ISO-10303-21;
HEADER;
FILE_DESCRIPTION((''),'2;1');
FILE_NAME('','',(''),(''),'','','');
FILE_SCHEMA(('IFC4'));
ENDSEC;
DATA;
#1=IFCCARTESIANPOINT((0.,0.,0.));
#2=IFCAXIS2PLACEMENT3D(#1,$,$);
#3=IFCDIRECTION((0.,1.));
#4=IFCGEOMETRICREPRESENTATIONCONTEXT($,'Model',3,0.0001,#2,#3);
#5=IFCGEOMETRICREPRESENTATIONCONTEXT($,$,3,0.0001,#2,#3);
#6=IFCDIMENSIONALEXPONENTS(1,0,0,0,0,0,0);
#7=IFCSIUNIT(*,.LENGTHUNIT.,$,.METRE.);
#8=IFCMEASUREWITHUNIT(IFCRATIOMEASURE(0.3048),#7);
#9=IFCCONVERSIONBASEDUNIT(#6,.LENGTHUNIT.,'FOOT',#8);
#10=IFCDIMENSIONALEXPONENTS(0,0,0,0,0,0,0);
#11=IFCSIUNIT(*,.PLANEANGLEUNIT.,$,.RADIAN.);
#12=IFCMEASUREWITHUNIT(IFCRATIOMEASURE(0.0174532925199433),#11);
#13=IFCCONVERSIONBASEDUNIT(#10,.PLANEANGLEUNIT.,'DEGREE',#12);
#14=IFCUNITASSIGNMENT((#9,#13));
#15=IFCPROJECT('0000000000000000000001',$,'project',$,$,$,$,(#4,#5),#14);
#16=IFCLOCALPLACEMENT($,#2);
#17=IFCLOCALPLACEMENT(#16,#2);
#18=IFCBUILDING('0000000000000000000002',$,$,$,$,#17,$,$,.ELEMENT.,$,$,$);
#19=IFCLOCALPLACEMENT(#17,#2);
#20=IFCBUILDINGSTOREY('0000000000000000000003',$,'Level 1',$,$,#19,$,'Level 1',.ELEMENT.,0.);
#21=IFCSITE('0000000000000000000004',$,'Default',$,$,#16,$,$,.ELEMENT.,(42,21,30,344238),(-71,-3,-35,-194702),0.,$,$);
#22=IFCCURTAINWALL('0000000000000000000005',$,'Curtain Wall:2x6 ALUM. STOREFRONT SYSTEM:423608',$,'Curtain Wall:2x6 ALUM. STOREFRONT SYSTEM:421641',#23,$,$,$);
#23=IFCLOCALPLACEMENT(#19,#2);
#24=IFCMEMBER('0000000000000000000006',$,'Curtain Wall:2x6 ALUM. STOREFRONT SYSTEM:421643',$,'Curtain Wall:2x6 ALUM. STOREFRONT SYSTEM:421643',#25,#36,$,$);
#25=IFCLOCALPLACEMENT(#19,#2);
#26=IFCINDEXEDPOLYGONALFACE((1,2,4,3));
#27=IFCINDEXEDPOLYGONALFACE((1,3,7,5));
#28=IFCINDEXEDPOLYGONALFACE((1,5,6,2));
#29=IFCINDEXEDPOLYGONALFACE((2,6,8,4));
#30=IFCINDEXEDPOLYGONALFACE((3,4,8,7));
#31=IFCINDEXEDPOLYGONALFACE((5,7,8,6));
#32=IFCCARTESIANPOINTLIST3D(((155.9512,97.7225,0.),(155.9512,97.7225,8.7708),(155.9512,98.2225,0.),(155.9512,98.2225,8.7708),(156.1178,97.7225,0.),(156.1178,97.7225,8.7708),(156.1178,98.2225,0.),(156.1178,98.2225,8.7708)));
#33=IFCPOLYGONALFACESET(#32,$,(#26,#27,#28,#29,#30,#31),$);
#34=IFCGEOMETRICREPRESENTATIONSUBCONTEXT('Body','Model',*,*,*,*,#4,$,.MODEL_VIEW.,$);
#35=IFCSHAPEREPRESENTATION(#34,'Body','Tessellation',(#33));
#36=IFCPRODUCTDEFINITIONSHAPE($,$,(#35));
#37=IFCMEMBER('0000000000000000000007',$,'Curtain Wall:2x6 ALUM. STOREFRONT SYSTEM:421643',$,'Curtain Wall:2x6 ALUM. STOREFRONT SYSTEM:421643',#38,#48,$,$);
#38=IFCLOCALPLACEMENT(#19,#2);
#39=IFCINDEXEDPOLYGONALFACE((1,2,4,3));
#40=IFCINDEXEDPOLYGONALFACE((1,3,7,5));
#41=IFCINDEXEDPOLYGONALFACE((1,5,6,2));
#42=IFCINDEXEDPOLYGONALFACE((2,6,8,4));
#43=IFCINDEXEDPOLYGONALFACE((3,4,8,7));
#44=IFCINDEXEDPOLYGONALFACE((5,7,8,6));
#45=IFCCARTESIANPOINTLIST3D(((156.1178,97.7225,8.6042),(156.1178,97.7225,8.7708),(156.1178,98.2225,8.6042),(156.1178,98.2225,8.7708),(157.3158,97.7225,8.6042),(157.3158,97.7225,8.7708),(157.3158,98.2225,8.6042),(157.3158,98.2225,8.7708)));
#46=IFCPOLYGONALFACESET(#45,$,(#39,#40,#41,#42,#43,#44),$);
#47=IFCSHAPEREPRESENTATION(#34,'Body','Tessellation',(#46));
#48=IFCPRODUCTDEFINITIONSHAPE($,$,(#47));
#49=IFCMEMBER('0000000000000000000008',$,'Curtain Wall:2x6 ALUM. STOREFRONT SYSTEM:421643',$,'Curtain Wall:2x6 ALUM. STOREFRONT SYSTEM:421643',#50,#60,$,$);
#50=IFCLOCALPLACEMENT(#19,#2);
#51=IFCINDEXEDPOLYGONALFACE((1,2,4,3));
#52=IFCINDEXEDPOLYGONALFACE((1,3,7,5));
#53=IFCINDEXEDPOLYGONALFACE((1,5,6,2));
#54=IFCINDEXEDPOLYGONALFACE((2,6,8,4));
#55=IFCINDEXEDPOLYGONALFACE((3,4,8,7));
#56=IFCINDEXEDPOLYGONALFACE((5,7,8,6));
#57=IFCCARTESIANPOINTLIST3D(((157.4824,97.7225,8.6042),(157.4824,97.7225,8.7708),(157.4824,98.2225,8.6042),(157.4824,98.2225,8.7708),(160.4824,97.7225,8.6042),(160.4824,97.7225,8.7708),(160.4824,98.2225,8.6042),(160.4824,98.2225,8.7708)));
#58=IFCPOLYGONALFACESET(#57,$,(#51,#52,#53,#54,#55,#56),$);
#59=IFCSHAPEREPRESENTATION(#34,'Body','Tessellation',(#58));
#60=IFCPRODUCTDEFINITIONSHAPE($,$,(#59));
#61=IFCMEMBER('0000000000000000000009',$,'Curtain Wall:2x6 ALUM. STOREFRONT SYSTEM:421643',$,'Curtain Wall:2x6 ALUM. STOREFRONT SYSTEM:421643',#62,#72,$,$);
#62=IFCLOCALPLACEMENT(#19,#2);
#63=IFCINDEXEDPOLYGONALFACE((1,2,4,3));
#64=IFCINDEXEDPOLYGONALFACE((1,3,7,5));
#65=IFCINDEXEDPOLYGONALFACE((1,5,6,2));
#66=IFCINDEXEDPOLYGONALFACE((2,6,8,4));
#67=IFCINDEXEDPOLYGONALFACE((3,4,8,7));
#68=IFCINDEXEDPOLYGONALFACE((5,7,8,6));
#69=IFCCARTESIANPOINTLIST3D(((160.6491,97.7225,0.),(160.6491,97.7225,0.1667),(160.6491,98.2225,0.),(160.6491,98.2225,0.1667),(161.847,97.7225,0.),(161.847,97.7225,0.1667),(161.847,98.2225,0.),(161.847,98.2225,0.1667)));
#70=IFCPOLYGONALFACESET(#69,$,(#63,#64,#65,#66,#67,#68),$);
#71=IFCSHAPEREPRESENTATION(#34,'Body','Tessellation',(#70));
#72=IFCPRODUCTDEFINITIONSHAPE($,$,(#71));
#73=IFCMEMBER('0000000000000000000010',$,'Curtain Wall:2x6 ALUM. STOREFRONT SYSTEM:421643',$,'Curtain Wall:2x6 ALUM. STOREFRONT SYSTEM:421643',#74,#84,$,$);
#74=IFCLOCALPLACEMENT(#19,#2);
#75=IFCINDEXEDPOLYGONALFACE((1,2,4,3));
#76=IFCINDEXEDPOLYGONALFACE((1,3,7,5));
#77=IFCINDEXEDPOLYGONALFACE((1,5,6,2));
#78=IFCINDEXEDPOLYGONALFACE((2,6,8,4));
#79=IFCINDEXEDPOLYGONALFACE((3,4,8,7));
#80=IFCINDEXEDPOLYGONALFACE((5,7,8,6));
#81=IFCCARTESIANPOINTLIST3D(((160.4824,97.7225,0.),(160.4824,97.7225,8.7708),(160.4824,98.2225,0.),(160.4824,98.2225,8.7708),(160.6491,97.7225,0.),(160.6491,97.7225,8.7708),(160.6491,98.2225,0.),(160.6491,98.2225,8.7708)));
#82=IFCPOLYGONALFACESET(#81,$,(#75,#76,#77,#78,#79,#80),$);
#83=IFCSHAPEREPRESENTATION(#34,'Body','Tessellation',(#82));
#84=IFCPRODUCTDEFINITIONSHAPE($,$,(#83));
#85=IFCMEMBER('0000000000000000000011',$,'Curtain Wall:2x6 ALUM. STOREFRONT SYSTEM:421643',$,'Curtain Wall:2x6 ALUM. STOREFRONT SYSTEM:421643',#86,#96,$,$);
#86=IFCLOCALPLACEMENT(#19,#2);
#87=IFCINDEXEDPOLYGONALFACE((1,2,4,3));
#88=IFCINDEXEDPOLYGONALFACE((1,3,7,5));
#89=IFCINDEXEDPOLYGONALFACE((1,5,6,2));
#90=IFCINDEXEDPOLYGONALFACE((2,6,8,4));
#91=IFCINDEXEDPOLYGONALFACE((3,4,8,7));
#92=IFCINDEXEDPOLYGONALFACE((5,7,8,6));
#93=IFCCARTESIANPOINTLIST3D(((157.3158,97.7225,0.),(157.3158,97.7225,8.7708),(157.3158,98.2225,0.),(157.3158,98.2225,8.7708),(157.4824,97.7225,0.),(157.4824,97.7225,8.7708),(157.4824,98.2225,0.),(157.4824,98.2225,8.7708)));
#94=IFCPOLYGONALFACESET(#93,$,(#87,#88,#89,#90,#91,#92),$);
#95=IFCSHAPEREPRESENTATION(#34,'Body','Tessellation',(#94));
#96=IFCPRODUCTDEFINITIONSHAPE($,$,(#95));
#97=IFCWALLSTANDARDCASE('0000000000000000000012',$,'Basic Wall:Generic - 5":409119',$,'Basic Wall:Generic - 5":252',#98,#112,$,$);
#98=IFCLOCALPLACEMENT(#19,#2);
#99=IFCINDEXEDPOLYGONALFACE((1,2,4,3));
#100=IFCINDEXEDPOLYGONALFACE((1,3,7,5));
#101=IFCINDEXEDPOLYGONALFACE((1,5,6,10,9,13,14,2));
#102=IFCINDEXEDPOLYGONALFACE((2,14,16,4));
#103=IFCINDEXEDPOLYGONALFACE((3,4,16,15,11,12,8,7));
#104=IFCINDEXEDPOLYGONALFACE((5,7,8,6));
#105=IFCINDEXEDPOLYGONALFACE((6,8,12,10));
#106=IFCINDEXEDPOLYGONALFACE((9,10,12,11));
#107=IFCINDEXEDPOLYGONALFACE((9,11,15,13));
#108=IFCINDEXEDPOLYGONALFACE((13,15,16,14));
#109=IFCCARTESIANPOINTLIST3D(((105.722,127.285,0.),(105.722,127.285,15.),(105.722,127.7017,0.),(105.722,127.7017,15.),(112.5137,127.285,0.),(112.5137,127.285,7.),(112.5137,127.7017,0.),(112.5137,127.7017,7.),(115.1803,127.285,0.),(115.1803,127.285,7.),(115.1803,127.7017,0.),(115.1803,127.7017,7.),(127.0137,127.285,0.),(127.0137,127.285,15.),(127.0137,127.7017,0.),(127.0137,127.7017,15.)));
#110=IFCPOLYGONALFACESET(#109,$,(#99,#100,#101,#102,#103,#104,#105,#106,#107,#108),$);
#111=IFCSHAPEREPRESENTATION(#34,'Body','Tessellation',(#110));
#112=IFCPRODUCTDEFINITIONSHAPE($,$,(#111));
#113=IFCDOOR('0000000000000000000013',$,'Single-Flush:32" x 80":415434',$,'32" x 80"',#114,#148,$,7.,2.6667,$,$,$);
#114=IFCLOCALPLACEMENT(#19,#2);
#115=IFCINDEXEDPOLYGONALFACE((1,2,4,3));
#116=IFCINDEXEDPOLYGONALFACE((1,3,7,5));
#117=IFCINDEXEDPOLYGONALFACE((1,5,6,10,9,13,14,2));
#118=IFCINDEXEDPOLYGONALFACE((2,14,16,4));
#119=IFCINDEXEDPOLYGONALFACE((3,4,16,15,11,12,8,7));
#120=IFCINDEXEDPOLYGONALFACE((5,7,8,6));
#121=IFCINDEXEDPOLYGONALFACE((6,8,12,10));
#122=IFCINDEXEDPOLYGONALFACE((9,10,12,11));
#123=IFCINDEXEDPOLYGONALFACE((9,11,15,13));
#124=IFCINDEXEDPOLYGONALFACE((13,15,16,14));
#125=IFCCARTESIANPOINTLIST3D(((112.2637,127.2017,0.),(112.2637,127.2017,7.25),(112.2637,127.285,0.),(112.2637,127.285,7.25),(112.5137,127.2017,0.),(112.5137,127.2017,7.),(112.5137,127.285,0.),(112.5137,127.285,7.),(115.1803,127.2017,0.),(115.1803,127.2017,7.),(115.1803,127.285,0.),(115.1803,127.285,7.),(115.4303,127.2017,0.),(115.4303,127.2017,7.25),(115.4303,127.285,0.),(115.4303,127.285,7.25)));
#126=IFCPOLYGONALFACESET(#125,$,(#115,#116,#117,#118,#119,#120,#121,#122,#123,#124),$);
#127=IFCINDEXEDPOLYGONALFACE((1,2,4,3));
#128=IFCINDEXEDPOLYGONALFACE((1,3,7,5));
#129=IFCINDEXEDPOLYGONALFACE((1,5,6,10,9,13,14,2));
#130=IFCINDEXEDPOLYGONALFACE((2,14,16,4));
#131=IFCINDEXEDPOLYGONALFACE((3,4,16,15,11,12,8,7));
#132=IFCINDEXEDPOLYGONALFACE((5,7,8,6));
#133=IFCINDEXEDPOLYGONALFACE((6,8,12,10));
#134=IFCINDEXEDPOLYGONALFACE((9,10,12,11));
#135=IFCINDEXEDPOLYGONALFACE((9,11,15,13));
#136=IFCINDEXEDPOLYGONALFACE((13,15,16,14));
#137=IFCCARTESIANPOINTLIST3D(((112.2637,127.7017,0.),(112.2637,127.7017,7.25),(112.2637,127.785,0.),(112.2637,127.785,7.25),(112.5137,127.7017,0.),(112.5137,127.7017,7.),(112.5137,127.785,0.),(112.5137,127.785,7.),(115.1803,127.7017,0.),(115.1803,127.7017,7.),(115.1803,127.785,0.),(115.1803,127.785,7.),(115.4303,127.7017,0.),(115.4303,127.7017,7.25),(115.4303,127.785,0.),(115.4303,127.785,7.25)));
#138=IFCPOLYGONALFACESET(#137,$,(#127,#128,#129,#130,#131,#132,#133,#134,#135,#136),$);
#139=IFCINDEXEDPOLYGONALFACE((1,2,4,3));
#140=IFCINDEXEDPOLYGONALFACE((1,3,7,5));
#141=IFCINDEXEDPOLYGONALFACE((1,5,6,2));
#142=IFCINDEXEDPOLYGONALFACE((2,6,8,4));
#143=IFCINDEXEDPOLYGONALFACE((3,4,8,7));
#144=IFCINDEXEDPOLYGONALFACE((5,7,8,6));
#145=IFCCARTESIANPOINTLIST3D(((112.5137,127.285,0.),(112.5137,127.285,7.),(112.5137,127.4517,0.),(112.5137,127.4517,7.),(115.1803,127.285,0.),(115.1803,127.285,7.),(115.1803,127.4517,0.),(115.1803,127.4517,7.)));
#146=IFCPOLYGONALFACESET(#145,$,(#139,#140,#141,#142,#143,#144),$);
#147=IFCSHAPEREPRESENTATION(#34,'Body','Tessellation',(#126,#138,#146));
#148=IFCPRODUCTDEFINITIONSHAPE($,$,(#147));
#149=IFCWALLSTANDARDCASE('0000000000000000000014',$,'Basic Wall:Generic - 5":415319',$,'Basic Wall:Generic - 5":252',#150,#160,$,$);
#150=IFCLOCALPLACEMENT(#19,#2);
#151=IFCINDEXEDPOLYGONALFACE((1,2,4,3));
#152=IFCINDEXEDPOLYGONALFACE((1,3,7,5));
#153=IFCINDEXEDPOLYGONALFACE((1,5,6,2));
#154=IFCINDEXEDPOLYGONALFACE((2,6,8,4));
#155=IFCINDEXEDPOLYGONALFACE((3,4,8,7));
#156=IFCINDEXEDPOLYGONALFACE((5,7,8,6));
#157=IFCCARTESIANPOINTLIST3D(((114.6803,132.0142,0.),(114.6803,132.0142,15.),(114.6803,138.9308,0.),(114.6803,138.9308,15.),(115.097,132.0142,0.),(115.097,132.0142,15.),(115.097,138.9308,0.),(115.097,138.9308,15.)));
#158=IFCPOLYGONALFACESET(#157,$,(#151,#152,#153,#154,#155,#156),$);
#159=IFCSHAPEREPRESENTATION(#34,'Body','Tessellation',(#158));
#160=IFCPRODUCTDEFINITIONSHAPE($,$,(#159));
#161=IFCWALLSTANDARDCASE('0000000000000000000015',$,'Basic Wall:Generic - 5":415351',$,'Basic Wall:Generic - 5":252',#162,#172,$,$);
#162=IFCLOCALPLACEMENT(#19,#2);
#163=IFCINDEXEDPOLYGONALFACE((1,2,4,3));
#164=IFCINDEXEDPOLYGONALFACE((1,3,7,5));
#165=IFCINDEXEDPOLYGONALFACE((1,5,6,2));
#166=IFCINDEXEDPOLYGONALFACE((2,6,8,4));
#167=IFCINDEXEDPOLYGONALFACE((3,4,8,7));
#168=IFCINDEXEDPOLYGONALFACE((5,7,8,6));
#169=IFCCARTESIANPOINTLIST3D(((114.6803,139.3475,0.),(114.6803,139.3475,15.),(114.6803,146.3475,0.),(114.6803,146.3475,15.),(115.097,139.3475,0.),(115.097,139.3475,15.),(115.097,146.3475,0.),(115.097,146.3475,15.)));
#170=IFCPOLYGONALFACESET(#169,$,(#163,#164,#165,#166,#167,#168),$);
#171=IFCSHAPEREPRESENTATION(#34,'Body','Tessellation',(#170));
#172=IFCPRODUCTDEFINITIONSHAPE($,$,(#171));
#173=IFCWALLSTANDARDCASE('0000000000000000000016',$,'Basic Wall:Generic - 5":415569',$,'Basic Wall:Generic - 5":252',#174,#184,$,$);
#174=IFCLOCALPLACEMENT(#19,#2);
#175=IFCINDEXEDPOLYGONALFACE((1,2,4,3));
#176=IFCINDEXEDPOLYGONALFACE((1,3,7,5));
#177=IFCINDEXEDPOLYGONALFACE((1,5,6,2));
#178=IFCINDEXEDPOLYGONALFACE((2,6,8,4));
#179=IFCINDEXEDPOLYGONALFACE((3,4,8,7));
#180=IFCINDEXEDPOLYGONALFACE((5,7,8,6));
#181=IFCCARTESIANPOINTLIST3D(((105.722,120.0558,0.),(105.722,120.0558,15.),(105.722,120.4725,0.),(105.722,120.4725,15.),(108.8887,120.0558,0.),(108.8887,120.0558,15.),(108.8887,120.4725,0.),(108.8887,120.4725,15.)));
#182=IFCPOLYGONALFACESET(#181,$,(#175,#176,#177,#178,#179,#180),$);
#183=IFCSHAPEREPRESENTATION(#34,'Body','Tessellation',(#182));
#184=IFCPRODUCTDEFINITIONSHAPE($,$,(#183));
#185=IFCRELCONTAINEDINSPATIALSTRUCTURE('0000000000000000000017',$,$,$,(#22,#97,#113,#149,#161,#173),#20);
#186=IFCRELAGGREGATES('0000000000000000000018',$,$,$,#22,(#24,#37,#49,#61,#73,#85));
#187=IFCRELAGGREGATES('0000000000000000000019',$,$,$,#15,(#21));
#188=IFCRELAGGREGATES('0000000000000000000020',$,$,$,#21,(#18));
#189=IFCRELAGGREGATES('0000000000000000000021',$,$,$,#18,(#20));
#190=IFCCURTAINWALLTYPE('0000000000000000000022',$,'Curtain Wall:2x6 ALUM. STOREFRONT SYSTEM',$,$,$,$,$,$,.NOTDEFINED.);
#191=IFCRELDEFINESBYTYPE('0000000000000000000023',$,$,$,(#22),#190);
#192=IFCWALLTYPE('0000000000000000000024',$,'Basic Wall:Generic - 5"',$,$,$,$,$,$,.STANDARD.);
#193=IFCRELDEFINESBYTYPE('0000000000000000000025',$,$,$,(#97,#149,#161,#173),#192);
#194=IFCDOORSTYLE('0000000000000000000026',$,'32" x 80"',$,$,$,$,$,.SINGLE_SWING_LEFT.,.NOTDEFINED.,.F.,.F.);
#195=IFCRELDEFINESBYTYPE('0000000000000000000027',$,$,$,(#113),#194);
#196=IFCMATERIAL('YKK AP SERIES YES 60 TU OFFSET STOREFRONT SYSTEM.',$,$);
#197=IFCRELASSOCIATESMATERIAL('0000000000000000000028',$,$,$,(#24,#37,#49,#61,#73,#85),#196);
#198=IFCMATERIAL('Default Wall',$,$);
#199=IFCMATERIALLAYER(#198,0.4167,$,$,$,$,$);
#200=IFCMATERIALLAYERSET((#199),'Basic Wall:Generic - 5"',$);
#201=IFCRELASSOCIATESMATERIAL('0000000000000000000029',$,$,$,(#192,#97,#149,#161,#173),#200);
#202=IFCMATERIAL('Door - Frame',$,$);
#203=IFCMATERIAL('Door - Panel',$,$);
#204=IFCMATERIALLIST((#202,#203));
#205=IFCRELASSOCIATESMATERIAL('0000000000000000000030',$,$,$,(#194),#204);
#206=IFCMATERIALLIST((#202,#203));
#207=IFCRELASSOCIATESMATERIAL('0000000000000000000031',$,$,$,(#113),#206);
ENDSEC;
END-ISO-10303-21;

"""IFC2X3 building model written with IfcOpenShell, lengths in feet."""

from ifc_helpers import new_model, entity, si_unit, converted_unit, direction, frame, frame_2d, origin, origin_2d_with_axis, place, context, subcontext, project, spatial, polyline, rectangle, outline, extrude, source, transform, mapped, material, material_list, layer, layer_set, layer_usage, type_object, type_shapes, element, fill, aggregate, save


model = new_model("IFC2X3")

# Units and contexts
model_context = context("Model", 3, precision=0.0001, world=origin(), true_north=direction((0.0, 1.0)))
context_of_model = context(None, 3, precision=0.0001, world=origin(), true_north=direction((0.0, 1.0)))
body_context = subcontext(model_context, "Body", "Model", "MODEL_VIEW")
ifc_project = project(units=[converted_unit("LENGTHUNIT", "FOOT", entity("IfcRatioMeasure", 0.3048), si_unit("LENGTHUNIT", "METRE"), dimensions=[1, 0, 0, 0, 0, 0, 0]), converted_unit("PLANEANGLEUNIT", "DEGREE", entity("IfcRatioMeasure", 0.0174532925199433), si_unit("PLANEANGLEUNIT", "RADIAN"), dimensions=[0, 0, 0, 0, 0, 0, 0])], contexts=[model_context, context_of_model])

# Site, building, storey
site_placement = place(None, origin())
site = spatial("IfcSite", under=ifc_project, at=site_placement, Name="Default", CompositionType="ELEMENT", RefLatitude=(42, 21, 30, 344238), RefLongitude=(-71, -3, -35, -194702), RefElevation=0.0)
building_placement = place(site_placement, origin())
building = spatial("IfcBuilding", under=site, at=building_placement, CompositionType="ELEMENT")
storey_placement = place(building_placement, origin())
storey = spatial("IfcBuildingStorey", under=building, at=storey_placement, Name="Level 1", LongName="Level 1", CompositionType="ELEMENT", Elevation=0.0)

# Curtain wall, members
curtain_wall_type = type_object("IfcCurtainWallType", Name="Curtain Wall:2x6 ALUM. STOREFRONT SYSTEM", PredefinedType="NOTDEFINED")
curtain_wall_placement = place(storey_placement, origin())
curtain_wall = element("IfcCurtainWall", 1, at=curtain_wall_placement, inside=storey, type_object=curtain_wall_type, Name="Curtain Wall:2x6 ALUM. STOREFRONT SYSTEM:423608", ObjectType="Curtain Wall:2x6 ALUM. STOREFRONT SYSTEM:421641")
ifc_material_1 = material(Name="YKK AP SERIES YES 60 TU OFFSET STOREFRONT SYSTEM.")
member_1_placement = place(curtain_wall_placement, origin())
member_1 = element("IfcMember", 2, at=member_1_placement, material=ifc_material_1, Name="Curtain Wall:2x6 ALUM. STOREFRONT SYSTEM:421643", ObjectType="Curtain Wall:2x6 ALUM. STOREFRONT SYSTEM:421643", context=body_context, shape_type="SweptSolid", body=[
    extrude(rectangle(XDim=0.1667, YDim=0.5, at=frame_2d((0.0, 0.0), x_axis=(1.0, 0.0))), frame((156.0345, 97.9725, 8.7708), z_axis=(0.0, 0.0, -1.0), x_axis=(-1.0, 0.0, 0.0)), (0.0, 0.0, 1.0), 8.7708),
])
member_2_placement = place(curtain_wall_placement, origin())
member_2 = element("IfcMember", 3, at=member_2_placement, material=ifc_material_1, Name="Curtain Wall:2x6 ALUM. STOREFRONT SYSTEM:421643", ObjectType="Curtain Wall:2x6 ALUM. STOREFRONT SYSTEM:421643", context=body_context, shape_type="SweptSolid", body=[
    extrude(rectangle(XDim=0.1667, YDim=0.5, at=frame_2d((0.0, 0.0), x_axis=(1.0, 0.0))), frame((157.3158, 97.9725, 8.6875), z_axis=(-1.0, 0.0, 0.0), x_axis=(0.0, 0.0, -1.0)), (0.0, 0.0, 1.0), 1.1979),
])
member_3_placement = place(curtain_wall_placement, origin())
member_3 = element("IfcMember", 4, at=member_3_placement, material=ifc_material_1, Name="Curtain Wall:2x6 ALUM. STOREFRONT SYSTEM:421643", ObjectType="Curtain Wall:2x6 ALUM. STOREFRONT SYSTEM:421643", context=body_context, shape_type="SweptSolid", body=[
    extrude(rectangle(XDim=0.1667, YDim=0.5, at=frame_2d((0.0, 0.0), x_axis=(1.0, 0.0))), frame((160.4824, 97.9725, 8.6875), z_axis=(-1.0, 0.0, 0.0), x_axis=(0.0, 0.0, -1.0)), (0.0, 0.0, 1.0), 3.0),
])
member_4_placement = place(curtain_wall_placement, origin())
member_4 = element("IfcMember", 5, at=member_4_placement, material=ifc_material_1, Name="Curtain Wall:2x6 ALUM. STOREFRONT SYSTEM:421643", ObjectType="Curtain Wall:2x6 ALUM. STOREFRONT SYSTEM:421643", context=body_context, shape_type="SweptSolid", body=[
    extrude(rectangle(XDim=0.1667, YDim=0.5, at=origin_2d_with_axis()), frame((160.6491, 97.9725, 0.0833), z_axis=(1.0, 0.0, 0.0), x_axis=(0.0, 0.0, -1.0)), (0.0, 0.0, 1.0), 1.1979),
])
member_5_placement = place(curtain_wall_placement, origin())
member_5 = element("IfcMember", 6, at=member_5_placement, material=ifc_material_1, Name="Curtain Wall:2x6 ALUM. STOREFRONT SYSTEM:421643", ObjectType="Curtain Wall:2x6 ALUM. STOREFRONT SYSTEM:421643", context=body_context, shape_type="SweptSolid", body=[
    extrude(rectangle(XDim=0.1667, YDim=0.5, at=origin_2d_with_axis()), frame((160.5658, 97.9725, 0.0), z_axis=(0.0, 0.0, 1.0), x_axis=(-1.0, 0.0, 0.0)), (0.0, 0.0, 1.0), 8.7708),
])
member_6_placement = place(curtain_wall_placement, origin())
member_6 = element("IfcMember", 7, at=member_6_placement, material=ifc_material_1, Name="Curtain Wall:2x6 ALUM. STOREFRONT SYSTEM:421643", ObjectType="Curtain Wall:2x6 ALUM. STOREFRONT SYSTEM:421643", context=body_context, shape_type="SweptSolid", body=[
    extrude(rectangle(XDim=0.1667, YDim=0.5, at=origin_2d_with_axis()), frame((157.3991, 97.9725, 0.0), z_axis=(0.0, 0.0, 1.0), x_axis=(-1.0, 0.0, 0.0)), (0.0, 0.0, 1.0), 8.7708),
])
aggregate(curtain_wall, [member_1, member_2, member_3, member_4, member_5, member_6])

# Shared definitions
ifc_material_2 = material(Name="Default Wall")
ifc_material_3 = material(Name="Door - Frame")
ifc_material_4 = material(Name="Door - Panel")

# Wall, opening, door
ifc_layer_1 = layer(ifc_material_2, 0.4167)
ifc_layer_set_1 = layer_set([ifc_layer_1], Name="Basic Wall:Generic - 5\"")
ifc_layer_usage_1 = layer_usage(ifc_layer_set_1, "AXIS2", "NEGATIVE", 0.2083)
wall_type_1 = type_object("IfcWallType", Name="Basic Wall:Generic - 5\"", PredefinedType="STANDARD", material=ifc_layer_set_1)
wall_1_placement = place(storey_placement, frame((127.0137, 127.4933, 0.0), z_axis=(0.0, 0.0, 1.0), x_axis=(-1.0, 0.0, 0.0)))
wall_1 = element("IfcWallStandardCase", 8, at=wall_1_placement, inside=storey, type_object=wall_type_1, material=ifc_layer_usage_1, Name="Basic Wall:Generic - 5\":409119", ObjectType="Basic Wall:Generic - 5\":252", context=body_context, shape_type="SweptSolid", body=[
    extrude(rectangle(XDim=21.2917, YDim=0.4167, at=frame_2d((10.6458, 0.0), x_axis=(-1.0, 0.0))), origin(), (0.0, 0.0, 1.0), 15.0),
])
opening_1_placement = place(wall_1_placement, frame((11.8333, -0.2083, 0.0)))
opening_1 = element("IfcOpeningElement", 9, at=opening_1_placement, cuts=wall_1, ObjectType="Opening", context=body_context, shape_type="SweptSolid", body=[
    extrude(rectangle(XDim=2.6667, YDim=7.0, at=frame_2d((3.5, 1.3333), x_axis=(0.0, -1.0))), frame((0.0, 0.0, 0.0), z_axis=(0.0, 1.0, 0.0), x_axis=(0.0, 0.0, 1.0)), (0.0, 0.0, 1.0), 0.4167),
])
ifc_material_list_1 = material_list([ifc_material_3, ifc_material_4])
ifc_material_list_2 = material_list([ifc_material_3, ifc_material_4])
door_style_1 = type_object("IfcDoorStyle", Name="32\" x 80\"", ConstructionType="NOTDEFINED", OperationType="SINGLE_SWING_LEFT", ParameterTakesPrecedence=False, Sizeable=False, material=ifc_material_list_2)
shared_shape_1 = source(origin(), body_context, "Body", "SweptSolid", [
    extrude(outline(polyline([(-1.5833, -3.6875), (1.5833, -3.6875), (1.5833, 3.5625), (1.3333, 3.5625), (1.3333, -3.4375), (-1.3333, -3.4375), (-1.3333, 3.5625), (-1.5833, 3.5625), (-1.5833, -3.6875)])), frame((1.3333, 0.5, 3.5625), z_axis=(0.0, -1.0, 0.0), x_axis=(-1.0, 0.0, 0.0)), (0.0, 0.0, 1.0), 0.0833),
    extrude(outline(polyline([(-3.6875, -1.5833), (3.5625, -1.5833), (3.5625, -1.3333), (-3.4375, -1.3333), (-3.4375, 1.3333), (3.5625, 1.3333), (3.5625, 1.5833), (-3.6875, 1.5833), (-3.6875, -1.5833)])), frame((1.3333, 0.0, 3.5625), z_axis=(0.0, -1.0, 0.0), x_axis=(0.0, 0.0, -1.0)), (0.0, 0.0, 1.0), 0.0833),
    extrude(rectangle(XDim=2.6667, YDim=0.1667, at=origin_2d_with_axis()), frame((1.3333, 0.3333, 0.0)), (0.0, 0.0, 1.0), 7.0),
])
type_shapes(door_style_1, [shared_shape_1])
door_1_placement = place(opening_1_placement, origin())
door_1 = element("IfcDoor", 10, at=door_1_placement, inside=storey, type_object=door_style_1, material=ifc_material_list_1, Name="Single-Flush:32\" x 80\":415434", ObjectType="32\" x 80\"", OverallHeight=7.0, OverallWidth=2.6667, context=body_context, shape_type="MappedRepresentation", body=[
    mapped(shared_shape_1, transform((0.0, 0.0, 0.0), scale=1.0)),
])
fill(opening_1, door_1)

# Walls
ifc_layer_usage_2 = layer_usage(ifc_layer_set_1, "AXIS2", "NEGATIVE", 0.2083)
wall_2_placement = place(storey_placement, frame((114.8887, 132.0142, 0.0), z_axis=(0.0, 0.0, 1.0), x_axis=(0.0, 1.0, 0.0)))
element("IfcWallStandardCase", 11, at=wall_2_placement, inside=storey, type_object=wall_type_1, material=ifc_layer_usage_2, Name="Basic Wall:Generic - 5\":415319", ObjectType="Basic Wall:Generic - 5\":252", context=body_context, shape_type="SweptSolid", body=[
    extrude(rectangle(XDim=6.9167, YDim=0.4167, at=frame_2d((3.4583, 0.0), x_axis=(-1.0, 0.0))), origin(), (0.0, 0.0, 1.0), 15.0),
])
ifc_layer_usage_3 = layer_usage(ifc_layer_set_1, "AXIS2", "NEGATIVE", 0.2083)
wall_3_placement = place(storey_placement, frame((114.8887, 139.3475, 0.0), z_axis=(0.0, 0.0, 1.0), x_axis=(0.0, 1.0, 0.0)))
element("IfcWallStandardCase", 12, at=wall_3_placement, inside=storey, type_object=wall_type_1, material=ifc_layer_usage_3, Name="Basic Wall:Generic - 5\":415351", ObjectType="Basic Wall:Generic - 5\":252", context=body_context, shape_type="SweptSolid", body=[
    extrude(rectangle(XDim=7.0, YDim=0.4167, at=frame_2d((3.5, 0.0), x_axis=(-1.0, 0.0))), origin(), (0.0, 0.0, 1.0), 15.0),
])
ifc_layer_usage_4 = layer_usage(ifc_layer_set_1, "AXIS2", "NEGATIVE", 0.2083)
wall_4_placement = place(storey_placement, frame((105.722, 120.2642, 0.0)))
element("IfcWallStandardCase", 13, at=wall_4_placement, inside=storey, type_object=wall_type_1, material=ifc_layer_usage_4, Name="Basic Wall:Generic - 5\":415569", ObjectType="Basic Wall:Generic - 5\":252", context=body_context, shape_type="SweptSolid", body=[
    extrude(rectangle(XDim=3.1667, YDim=0.4167, at=frame_2d((1.5833, 0.0), x_axis=(-1.0, 0.0))), origin(), (0.0, 0.0, 1.0), 15.0),
])

save(model, "model.ifc")
